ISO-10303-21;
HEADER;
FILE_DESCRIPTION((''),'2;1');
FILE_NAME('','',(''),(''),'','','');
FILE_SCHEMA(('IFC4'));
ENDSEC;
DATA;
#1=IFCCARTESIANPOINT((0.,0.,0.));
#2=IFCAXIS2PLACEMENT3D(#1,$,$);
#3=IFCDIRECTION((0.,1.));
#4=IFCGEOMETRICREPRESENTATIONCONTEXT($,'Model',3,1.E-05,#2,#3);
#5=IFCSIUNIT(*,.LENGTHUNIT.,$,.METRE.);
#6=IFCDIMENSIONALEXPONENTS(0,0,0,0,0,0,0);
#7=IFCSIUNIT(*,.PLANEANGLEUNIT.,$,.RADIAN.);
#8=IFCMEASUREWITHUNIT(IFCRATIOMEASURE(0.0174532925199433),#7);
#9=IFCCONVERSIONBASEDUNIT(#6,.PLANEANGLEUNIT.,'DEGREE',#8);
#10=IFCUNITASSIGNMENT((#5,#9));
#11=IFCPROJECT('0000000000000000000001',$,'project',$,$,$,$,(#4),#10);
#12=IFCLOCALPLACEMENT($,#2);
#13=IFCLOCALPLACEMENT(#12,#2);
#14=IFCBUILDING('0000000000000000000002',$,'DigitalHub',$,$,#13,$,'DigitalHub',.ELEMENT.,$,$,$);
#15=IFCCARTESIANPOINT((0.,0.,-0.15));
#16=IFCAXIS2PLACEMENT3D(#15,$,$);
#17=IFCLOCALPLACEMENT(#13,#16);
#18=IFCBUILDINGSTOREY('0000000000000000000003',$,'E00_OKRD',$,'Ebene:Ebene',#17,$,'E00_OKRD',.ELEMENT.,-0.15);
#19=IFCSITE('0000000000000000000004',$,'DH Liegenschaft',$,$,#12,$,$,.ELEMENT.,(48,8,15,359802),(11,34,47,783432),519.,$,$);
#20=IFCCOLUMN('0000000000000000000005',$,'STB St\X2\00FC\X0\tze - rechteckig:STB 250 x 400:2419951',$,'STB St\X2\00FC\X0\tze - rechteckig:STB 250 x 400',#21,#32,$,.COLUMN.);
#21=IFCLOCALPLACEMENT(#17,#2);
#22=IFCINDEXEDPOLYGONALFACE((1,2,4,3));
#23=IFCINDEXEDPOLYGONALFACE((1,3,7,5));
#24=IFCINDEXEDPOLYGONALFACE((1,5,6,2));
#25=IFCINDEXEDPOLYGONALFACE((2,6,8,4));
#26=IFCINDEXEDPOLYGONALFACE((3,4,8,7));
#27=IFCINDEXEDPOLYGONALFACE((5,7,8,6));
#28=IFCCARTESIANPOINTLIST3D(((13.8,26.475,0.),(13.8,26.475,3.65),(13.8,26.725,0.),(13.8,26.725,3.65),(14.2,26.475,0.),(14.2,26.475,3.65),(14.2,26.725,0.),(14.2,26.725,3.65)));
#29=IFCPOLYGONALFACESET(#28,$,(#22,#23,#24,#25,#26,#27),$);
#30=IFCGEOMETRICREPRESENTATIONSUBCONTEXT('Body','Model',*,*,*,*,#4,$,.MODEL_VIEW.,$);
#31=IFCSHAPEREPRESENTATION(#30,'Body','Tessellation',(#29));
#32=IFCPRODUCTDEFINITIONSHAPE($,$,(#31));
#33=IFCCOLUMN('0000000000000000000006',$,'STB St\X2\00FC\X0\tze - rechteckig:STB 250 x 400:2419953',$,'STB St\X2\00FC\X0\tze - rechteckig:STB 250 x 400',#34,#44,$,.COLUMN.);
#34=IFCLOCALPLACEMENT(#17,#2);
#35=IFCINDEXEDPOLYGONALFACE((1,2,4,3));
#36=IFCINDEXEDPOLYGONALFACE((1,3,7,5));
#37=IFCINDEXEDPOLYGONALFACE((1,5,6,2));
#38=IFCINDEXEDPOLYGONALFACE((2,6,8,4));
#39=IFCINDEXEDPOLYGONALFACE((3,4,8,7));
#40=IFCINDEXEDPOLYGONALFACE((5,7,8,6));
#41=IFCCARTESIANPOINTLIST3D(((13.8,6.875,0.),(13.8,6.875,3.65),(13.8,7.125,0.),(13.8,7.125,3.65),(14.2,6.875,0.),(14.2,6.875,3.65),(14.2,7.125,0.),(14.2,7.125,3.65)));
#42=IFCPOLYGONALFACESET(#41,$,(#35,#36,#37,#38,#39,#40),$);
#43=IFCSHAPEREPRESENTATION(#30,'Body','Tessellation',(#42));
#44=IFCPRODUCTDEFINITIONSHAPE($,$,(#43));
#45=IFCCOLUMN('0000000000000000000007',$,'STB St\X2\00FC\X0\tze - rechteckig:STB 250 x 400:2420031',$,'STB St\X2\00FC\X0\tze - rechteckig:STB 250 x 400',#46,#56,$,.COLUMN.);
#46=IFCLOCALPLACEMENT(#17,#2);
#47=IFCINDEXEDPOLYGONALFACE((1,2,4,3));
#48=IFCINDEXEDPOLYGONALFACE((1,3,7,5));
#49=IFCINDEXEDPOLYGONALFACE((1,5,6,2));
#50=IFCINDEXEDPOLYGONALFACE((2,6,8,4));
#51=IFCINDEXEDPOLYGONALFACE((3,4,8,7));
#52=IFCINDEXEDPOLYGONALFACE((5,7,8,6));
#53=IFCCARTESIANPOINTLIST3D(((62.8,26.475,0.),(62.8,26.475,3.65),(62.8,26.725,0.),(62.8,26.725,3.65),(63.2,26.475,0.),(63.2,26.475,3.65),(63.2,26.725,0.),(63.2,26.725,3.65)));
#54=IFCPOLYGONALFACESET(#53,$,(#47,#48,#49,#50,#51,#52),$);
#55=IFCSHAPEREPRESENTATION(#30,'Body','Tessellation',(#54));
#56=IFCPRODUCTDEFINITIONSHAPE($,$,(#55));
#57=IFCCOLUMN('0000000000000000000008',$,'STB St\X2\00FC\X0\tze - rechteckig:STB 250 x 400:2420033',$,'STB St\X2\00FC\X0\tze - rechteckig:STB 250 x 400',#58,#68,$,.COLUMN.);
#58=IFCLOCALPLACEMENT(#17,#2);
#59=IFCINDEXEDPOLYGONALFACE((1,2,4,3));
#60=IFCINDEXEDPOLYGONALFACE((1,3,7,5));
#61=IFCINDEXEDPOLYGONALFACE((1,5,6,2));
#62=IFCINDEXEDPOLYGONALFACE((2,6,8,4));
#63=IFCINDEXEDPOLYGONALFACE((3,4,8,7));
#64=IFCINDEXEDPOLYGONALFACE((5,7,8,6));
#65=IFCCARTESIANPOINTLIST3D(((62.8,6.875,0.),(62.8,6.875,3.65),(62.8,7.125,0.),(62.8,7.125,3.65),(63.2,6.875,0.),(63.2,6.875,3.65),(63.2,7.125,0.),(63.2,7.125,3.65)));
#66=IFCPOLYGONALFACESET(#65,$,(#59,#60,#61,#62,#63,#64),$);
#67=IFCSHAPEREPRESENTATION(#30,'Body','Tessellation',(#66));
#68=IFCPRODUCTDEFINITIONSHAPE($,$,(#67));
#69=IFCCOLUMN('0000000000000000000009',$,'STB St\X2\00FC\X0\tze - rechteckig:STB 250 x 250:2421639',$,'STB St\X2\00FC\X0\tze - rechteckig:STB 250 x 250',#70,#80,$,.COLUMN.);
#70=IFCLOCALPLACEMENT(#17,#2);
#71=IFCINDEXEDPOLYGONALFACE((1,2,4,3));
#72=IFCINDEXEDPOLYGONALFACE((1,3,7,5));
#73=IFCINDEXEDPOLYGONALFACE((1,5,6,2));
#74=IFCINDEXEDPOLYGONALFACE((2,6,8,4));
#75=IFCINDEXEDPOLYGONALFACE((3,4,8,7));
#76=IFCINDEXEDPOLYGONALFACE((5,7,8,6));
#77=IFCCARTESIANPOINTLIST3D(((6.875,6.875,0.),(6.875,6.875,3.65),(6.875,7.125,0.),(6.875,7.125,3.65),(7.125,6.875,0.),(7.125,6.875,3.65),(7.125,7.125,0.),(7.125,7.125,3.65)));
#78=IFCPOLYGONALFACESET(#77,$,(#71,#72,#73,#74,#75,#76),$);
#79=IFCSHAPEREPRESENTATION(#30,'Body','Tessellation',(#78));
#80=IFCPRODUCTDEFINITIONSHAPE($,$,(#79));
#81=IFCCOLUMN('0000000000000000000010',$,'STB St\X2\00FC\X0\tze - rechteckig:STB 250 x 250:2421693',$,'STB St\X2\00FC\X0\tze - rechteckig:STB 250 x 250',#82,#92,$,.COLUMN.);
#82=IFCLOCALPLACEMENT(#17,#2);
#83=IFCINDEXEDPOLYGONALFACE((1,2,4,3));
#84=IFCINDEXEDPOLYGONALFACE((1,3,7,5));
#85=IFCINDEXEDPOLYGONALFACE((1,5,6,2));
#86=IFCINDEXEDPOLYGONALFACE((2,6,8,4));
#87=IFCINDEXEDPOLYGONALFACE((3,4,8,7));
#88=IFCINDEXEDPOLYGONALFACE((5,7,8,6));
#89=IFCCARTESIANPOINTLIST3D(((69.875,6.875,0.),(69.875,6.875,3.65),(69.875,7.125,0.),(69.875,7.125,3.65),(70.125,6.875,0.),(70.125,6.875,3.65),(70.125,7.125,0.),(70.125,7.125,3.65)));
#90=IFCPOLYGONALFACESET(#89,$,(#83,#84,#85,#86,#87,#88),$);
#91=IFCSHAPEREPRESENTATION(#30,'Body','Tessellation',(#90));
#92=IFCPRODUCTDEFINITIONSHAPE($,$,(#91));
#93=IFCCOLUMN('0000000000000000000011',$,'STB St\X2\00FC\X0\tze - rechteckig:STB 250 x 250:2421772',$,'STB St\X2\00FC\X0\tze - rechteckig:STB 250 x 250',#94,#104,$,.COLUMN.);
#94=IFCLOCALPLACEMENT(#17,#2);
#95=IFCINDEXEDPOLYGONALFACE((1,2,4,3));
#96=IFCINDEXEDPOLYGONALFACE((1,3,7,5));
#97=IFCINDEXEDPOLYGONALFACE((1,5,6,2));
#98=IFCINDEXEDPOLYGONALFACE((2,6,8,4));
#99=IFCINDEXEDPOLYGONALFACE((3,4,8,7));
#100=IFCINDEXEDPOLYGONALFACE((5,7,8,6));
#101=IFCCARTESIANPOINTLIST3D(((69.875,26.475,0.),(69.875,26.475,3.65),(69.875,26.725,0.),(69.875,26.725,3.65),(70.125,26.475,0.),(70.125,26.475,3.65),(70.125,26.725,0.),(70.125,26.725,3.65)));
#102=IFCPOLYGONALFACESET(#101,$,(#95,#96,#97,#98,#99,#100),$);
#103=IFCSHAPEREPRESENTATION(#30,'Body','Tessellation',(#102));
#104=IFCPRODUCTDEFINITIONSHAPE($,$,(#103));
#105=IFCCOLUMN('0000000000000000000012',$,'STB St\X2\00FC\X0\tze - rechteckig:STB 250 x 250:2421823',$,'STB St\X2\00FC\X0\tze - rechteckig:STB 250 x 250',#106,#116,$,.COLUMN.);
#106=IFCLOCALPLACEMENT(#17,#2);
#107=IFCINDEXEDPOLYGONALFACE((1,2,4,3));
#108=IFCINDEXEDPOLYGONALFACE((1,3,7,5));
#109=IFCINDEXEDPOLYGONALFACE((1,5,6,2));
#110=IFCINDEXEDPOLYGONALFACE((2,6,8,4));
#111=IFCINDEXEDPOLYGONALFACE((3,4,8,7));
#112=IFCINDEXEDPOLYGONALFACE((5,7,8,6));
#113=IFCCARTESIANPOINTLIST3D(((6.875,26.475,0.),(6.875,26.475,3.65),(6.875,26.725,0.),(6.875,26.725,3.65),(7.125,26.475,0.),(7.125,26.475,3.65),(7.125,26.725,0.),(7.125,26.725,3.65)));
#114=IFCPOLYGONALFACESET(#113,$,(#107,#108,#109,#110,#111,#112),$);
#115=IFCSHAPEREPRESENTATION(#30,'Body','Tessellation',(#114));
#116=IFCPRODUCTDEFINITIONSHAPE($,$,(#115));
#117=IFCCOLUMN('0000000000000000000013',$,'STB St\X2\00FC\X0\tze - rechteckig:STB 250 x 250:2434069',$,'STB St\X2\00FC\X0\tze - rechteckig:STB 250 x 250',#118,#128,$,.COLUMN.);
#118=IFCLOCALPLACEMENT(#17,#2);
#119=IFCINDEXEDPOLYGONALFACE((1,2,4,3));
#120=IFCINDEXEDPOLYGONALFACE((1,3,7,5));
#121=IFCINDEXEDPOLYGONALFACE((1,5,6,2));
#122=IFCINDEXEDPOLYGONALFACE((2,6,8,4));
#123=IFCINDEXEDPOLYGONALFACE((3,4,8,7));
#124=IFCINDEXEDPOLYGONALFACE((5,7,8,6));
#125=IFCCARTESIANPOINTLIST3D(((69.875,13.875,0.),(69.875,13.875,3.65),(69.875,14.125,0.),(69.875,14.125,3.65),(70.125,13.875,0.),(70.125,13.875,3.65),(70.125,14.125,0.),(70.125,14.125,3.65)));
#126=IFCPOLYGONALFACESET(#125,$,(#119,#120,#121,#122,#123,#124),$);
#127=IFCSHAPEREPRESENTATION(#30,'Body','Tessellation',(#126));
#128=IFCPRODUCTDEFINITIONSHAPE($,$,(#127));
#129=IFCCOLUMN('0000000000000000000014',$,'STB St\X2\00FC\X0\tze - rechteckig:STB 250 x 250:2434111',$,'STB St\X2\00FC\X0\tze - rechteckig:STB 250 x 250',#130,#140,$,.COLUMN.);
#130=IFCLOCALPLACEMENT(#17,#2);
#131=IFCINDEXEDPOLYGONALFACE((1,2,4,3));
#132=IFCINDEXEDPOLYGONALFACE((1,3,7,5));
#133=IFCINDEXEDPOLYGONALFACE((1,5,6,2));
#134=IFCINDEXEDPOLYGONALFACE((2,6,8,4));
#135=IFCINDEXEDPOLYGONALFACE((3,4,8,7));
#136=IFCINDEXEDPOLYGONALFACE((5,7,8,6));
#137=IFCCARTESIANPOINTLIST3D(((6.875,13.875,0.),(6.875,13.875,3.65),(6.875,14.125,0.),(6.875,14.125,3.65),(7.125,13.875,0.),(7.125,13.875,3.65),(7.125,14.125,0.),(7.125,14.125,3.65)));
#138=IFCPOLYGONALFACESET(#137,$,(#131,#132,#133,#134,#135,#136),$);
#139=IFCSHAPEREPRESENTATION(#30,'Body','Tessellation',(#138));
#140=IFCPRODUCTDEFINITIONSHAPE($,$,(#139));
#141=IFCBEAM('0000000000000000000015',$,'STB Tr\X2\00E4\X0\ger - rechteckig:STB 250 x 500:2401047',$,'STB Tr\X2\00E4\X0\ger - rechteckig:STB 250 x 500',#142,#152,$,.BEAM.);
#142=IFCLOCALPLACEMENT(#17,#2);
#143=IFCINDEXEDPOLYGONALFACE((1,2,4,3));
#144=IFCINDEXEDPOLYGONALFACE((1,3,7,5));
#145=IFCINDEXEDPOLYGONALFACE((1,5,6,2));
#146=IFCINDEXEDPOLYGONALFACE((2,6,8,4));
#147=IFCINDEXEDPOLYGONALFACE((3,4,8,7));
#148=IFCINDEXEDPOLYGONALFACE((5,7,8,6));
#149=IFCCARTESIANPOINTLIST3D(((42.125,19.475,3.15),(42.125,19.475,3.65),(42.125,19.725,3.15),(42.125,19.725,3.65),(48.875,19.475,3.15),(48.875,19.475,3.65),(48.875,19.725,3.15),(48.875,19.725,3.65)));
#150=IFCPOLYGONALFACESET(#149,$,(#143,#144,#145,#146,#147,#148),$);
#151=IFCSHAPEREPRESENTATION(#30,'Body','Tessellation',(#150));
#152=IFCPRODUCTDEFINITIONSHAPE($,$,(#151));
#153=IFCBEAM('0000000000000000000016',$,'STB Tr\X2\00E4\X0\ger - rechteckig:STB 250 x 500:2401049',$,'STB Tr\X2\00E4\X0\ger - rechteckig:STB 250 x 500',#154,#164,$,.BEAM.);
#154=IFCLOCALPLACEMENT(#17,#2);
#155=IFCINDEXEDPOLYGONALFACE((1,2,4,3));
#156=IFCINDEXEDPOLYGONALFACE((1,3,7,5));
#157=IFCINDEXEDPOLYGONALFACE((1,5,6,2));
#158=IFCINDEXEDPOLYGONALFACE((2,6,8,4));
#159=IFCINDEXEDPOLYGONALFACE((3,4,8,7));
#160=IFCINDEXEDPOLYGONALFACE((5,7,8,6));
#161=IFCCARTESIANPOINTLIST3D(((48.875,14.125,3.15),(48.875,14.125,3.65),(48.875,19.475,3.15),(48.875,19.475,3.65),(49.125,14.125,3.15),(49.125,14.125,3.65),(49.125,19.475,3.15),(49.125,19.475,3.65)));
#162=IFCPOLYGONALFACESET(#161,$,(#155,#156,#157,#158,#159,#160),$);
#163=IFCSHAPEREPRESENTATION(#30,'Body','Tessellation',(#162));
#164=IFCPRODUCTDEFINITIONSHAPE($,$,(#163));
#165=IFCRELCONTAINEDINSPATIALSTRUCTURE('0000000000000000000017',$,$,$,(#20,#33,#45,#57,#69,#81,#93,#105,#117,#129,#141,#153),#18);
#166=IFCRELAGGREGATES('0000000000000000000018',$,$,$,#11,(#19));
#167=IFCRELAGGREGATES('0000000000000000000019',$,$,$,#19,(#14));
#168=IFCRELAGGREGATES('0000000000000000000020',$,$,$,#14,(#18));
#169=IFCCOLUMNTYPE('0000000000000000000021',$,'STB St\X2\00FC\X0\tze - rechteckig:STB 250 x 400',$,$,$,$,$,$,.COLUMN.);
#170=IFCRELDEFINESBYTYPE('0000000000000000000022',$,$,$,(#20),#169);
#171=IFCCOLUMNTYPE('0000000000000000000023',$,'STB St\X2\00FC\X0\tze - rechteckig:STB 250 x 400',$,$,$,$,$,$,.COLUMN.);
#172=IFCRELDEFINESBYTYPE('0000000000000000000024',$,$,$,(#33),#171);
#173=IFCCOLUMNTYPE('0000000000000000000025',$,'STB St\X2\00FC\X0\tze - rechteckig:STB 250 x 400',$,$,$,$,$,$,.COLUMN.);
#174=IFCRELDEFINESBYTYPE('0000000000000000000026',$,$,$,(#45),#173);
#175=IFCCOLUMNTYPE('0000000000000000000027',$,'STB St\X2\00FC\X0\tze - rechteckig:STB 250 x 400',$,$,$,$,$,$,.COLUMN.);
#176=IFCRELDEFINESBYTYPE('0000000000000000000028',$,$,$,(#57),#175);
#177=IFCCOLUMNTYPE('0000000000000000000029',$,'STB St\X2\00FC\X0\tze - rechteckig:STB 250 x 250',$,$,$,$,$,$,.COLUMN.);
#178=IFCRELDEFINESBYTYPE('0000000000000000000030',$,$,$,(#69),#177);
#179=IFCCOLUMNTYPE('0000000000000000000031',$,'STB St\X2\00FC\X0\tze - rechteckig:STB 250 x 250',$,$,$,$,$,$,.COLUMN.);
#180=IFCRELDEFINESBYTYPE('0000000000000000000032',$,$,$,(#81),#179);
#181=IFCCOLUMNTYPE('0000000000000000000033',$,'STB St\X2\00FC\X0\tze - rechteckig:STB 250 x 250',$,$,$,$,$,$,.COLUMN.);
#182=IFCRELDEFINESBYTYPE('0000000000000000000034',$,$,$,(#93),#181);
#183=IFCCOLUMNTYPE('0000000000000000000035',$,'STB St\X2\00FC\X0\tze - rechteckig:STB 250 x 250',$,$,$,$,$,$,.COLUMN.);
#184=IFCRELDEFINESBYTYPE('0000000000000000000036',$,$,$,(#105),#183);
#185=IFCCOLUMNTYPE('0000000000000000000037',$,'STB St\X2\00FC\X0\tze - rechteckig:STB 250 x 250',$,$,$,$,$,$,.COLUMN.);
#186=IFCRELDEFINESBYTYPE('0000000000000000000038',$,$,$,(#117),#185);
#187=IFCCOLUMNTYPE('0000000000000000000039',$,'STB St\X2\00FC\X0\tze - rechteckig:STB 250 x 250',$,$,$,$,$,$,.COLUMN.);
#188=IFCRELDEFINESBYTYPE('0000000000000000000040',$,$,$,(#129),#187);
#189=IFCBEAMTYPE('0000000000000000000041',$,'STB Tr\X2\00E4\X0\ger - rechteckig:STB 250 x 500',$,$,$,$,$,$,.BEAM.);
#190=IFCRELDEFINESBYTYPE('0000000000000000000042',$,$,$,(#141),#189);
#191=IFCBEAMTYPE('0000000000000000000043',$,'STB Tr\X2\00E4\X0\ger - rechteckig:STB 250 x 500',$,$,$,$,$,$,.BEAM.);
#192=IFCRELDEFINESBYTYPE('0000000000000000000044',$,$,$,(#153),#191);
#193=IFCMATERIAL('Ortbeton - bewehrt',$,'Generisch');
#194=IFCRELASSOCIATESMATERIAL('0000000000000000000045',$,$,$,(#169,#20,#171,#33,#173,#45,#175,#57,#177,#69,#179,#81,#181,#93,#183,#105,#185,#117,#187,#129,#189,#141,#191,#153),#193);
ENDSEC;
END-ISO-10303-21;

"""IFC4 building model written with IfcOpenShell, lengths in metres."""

from ifc_helpers import new_model, entity, si_unit, converted_unit, direction, frame, origin, place, context, subcontext, project, spatial, indexed_curve, outline, extrude, source, transform, mapped, material, type_object, type_shapes, element, save


model = new_model("IFC4")

# Units and contexts
model_context = context("Model", 3, precision=1e-05, world=origin(), true_north=direction((0.0, 1.0)))
body_context = subcontext(model_context, "Body", "Model", "MODEL_VIEW")
ifc_project = project(units=[si_unit("LENGTHUNIT", "METRE"), converted_unit("PLANEANGLEUNIT", "DEGREE", entity("IfcRatioMeasure", 0.0174532925199433), si_unit("PLANEANGLEUNIT", "RADIAN"), dimensions=[0, 0, 0, 0, 0, 0, 0])], contexts=[model_context])

# Site, building, storey
site_placement = place(None, frame((0.0, 0.0, 0.0)))
site = spatial("IfcSite", under=ifc_project, at=site_placement, Name="DH Liegenschaft", CompositionType="ELEMENT", RefLatitude=(48, 8, 15, 359802), RefLongitude=(11, 34, 47, 783432), RefElevation=519.0)
building_placement = place(site_placement, origin())
building = spatial("IfcBuilding", under=site, at=building_placement, Name="DigitalHub", LongName="DigitalHub", CompositionType="ELEMENT")
storey_placement = place(building_placement, frame((0.0, 0.0, -0.15)))
storey = spatial("IfcBuildingStorey", under=building, at=storey_placement, Name="E00_OKRD", ObjectType="Ebene:Ebene", LongName="E00_OKRD", CompositionType="ELEMENT", Elevation=-0.15)

# Columns
ifc_material_1 = material(Name="Ortbeton - bewehrt", Category="Generisch")
column_type_1 = type_object("IfcColumnType", Name="STB Stütze - rechteckig:STB 250 x 400", PredefinedType="COLUMN", material=ifc_material_1)
shared_shape_1 = source(origin(), body_context, "Body", "SweptSolid", [
    extrude(outline(indexed_curve([(-0.125, -0.2), (0.125, -0.2), (0.125, 0.2), (-0.125, 0.2), (-0.125, -0.2)], self_intersect=False)), frame((14.0, 26.6, -0.15), z_axis=(0.0, 0.0, 1.0), x_axis=(0.0, -1.0, 0.0)), (0.0, 0.0, 1.0), 3.65),
])
type_shapes(column_type_1, [shared_shape_1])
column_1_placement = place(storey_placement, frame((0.0, 0.0, 0.15)))
element("IfcColumn", 1, at=column_1_placement, inside=storey, type_object=column_type_1, material=ifc_material_1, Name="STB Stütze - rechteckig:STB 250 x 400:2419951", ObjectType="STB Stütze - rechteckig:STB 250 x 400", PredefinedType="COLUMN", context=body_context, shape_type="MappedRepresentation", body=[
    mapped(shared_shape_1, transform((0.0, 0.0, 0.0), scale=1.0)),
])
column_type_2 = type_object("IfcColumnType", Name="STB Stütze - rechteckig:STB 250 x 400", PredefinedType="COLUMN", material=ifc_material_1)
shared_shape_2 = source(origin(), body_context, "Body", "SweptSolid", [
    extrude(outline(indexed_curve([(-0.125, -0.2), (0.125, -0.2), (0.125, 0.2), (-0.125, 0.2), (-0.125, -0.2)], self_intersect=False)), frame((14.0, 7.0, -0.15), z_axis=(0.0, 0.0, 1.0), x_axis=(0.0, -1.0, 0.0)), (0.0, 0.0, 1.0), 3.65),
])
type_shapes(column_type_2, [shared_shape_2])
column_2_placement = place(storey_placement, frame((0.0, 0.0, 0.15)))
element("IfcColumn", 2, at=column_2_placement, inside=storey, type_object=column_type_2, material=ifc_material_1, Name="STB Stütze - rechteckig:STB 250 x 400:2419953", ObjectType="STB Stütze - rechteckig:STB 250 x 400", PredefinedType="COLUMN", context=body_context, shape_type="MappedRepresentation", body=[
    mapped(shared_shape_2, transform((0.0, 0.0, 0.0), scale=1.0)),
])
column_type_3 = type_object("IfcColumnType", Name="STB Stütze - rechteckig:STB 250 x 400", PredefinedType="COLUMN", material=ifc_material_1)
shared_shape_3 = source(origin(), body_context, "Body", "SweptSolid", [
    extrude(outline(indexed_curve([(-0.125, -0.2), (0.125, -0.2), (0.125, 0.2), (-0.125, 0.2), (-0.125, -0.2)], self_intersect=False)), frame((63.0, 26.6, -0.15), z_axis=(0.0, 0.0, 1.0), x_axis=(0.0, -1.0, 0.0)), (0.0, 0.0, 1.0), 3.65),
])
type_shapes(column_type_3, [shared_shape_3])
column_3_placement = place(storey_placement, frame((0.0, 0.0, 0.15)))
element("IfcColumn", 3, at=column_3_placement, inside=storey, type_object=column_type_3, material=ifc_material_1, Name="STB Stütze - rechteckig:STB 250 x 400:2420031", ObjectType="STB Stütze - rechteckig:STB 250 x 400", PredefinedType="COLUMN", context=body_context, shape_type="MappedRepresentation", body=[
    mapped(shared_shape_3, transform((0.0, 0.0, 0.0), scale=1.0)),
])
column_type_4 = type_object("IfcColumnType", Name="STB Stütze - rechteckig:STB 250 x 400", PredefinedType="COLUMN", material=ifc_material_1)
shared_shape_4 = source(origin(), body_context, "Body", "SweptSolid", [
    extrude(outline(indexed_curve([(-0.125, -0.2), (0.125, -0.2), (0.125, 0.2), (-0.125, 0.2), (-0.125, -0.2)], self_intersect=False)), frame((63.0, 7.0, -0.15), z_axis=(0.0, 0.0, 1.0), x_axis=(0.0, -1.0, 0.0)), (0.0, 0.0, 1.0), 3.65),
])
type_shapes(column_type_4, [shared_shape_4])
column_4_placement = place(storey_placement, frame((0.0, 0.0, 0.15)))
element("IfcColumn", 4, at=column_4_placement, inside=storey, type_object=column_type_4, material=ifc_material_1, Name="STB Stütze - rechteckig:STB 250 x 400:2420033", ObjectType="STB Stütze - rechteckig:STB 250 x 400", PredefinedType="COLUMN", context=body_context, shape_type="MappedRepresentation", body=[
    mapped(shared_shape_4, transform((0.0, 0.0, 0.0), scale=1.0)),
])
column_type_5 = type_object("IfcColumnType", Name="STB Stütze - rechteckig:STB 250 x 250", PredefinedType="COLUMN", material=ifc_material_1)
shared_shape_5 = source(origin(), body_context, "Body", "SweptSolid", [
    extrude(outline(indexed_curve([(-0.125, -0.125), (0.125, -0.125), (0.125, 0.125), (-0.125, 0.125), (-0.125, -0.125)], self_intersect=False)), frame((7.0, 7.0, -0.15), z_axis=(0.0, 0.0, 1.0), x_axis=(0.0, -1.0, 0.0)), (0.0, 0.0, 1.0), 3.65),
])
type_shapes(column_type_5, [shared_shape_5])
column_5_placement = place(storey_placement, frame((0.0, 0.0, 0.15)))
element("IfcColumn", 5, at=column_5_placement, inside=storey, type_object=column_type_5, material=ifc_material_1, Name="STB Stütze - rechteckig:STB 250 x 250:2421639", ObjectType="STB Stütze - rechteckig:STB 250 x 250", PredefinedType="COLUMN", context=body_context, shape_type="MappedRepresentation", body=[
    mapped(shared_shape_5, transform((0.0, 0.0, 0.0), scale=1.0)),
])
column_type_6 = type_object("IfcColumnType", Name="STB Stütze - rechteckig:STB 250 x 250", PredefinedType="COLUMN", material=ifc_material_1)
shared_shape_6 = source(origin(), body_context, "Body", "SweptSolid", [
    extrude(outline(indexed_curve([(-0.125, -0.125), (0.125, -0.125), (0.125, 0.125), (-0.125, 0.125), (-0.125, -0.125)], self_intersect=False)), frame((70.0, 7.0, -0.15), z_axis=(0.0, 0.0, 1.0), x_axis=(0.0, -1.0, 0.0)), (0.0, 0.0, 1.0), 3.65),
])
type_shapes(column_type_6, [shared_shape_6])
column_6_placement = place(storey_placement, frame((0.0, 0.0, 0.15)))
element("IfcColumn", 6, at=column_6_placement, inside=storey, type_object=column_type_6, material=ifc_material_1, Name="STB Stütze - rechteckig:STB 250 x 250:2421693", ObjectType="STB Stütze - rechteckig:STB 250 x 250", PredefinedType="COLUMN", context=body_context, shape_type="MappedRepresentation", body=[
    mapped(shared_shape_6, transform((0.0, 0.0, 0.0), scale=1.0)),
])
column_type_7 = type_object("IfcColumnType", Name="STB Stütze - rechteckig:STB 250 x 250", PredefinedType="COLUMN", material=ifc_material_1)
shared_shape_7 = source(origin(), body_context, "Body", "SweptSolid", [
    extrude(outline(indexed_curve([(-0.125, -0.125), (0.125, -0.125), (0.125, 0.125), (-0.125, 0.125), (-0.125, -0.125)], self_intersect=False)), frame((70.0, 26.6, -0.15), z_axis=(0.0, 0.0, 1.0), x_axis=(0.0, -1.0, 0.0)), (0.0, 0.0, 1.0), 3.65),
])
type_shapes(column_type_7, [shared_shape_7])
column_7_placement = place(storey_placement, frame((0.0, 0.0, 0.15)))
element("IfcColumn", 7, at=column_7_placement, inside=storey, type_object=column_type_7, material=ifc_material_1, Name="STB Stütze - rechteckig:STB 250 x 250:2421772", ObjectType="STB Stütze - rechteckig:STB 250 x 250", PredefinedType="COLUMN", context=body_context, shape_type="MappedRepresentation", body=[
    mapped(shared_shape_7, transform((0.0, 0.0, 0.0), scale=1.0)),
])
column_type_8 = type_object("IfcColumnType", Name="STB Stütze - rechteckig:STB 250 x 250", PredefinedType="COLUMN", material=ifc_material_1)
shared_shape_8 = source(origin(), body_context, "Body", "SweptSolid", [
    extrude(outline(indexed_curve([(-0.125, -0.125), (0.125, -0.125), (0.125, 0.125), (-0.125, 0.125), (-0.125, -0.125)], self_intersect=False)), frame((7.0, 26.6, -0.15), z_axis=(0.0, 0.0, 1.0), x_axis=(0.0, -1.0, 0.0)), (0.0, 0.0, 1.0), 3.65),
])
type_shapes(column_type_8, [shared_shape_8])
column_8_placement = place(storey_placement, frame((0.0, 0.0, 0.15)))
element("IfcColumn", 8, at=column_8_placement, inside=storey, type_object=column_type_8, material=ifc_material_1, Name="STB Stütze - rechteckig:STB 250 x 250:2421823", ObjectType="STB Stütze - rechteckig:STB 250 x 250", PredefinedType="COLUMN", context=body_context, shape_type="MappedRepresentation", body=[
    mapped(shared_shape_8, transform((0.0, 0.0, 0.0), scale=1.0)),
])
column_type_9 = type_object("IfcColumnType", Name="STB Stütze - rechteckig:STB 250 x 250", PredefinedType="COLUMN", material=ifc_material_1)
shared_shape_9 = source(origin(), body_context, "Body", "SweptSolid", [
    extrude(outline(indexed_curve([(-0.125, -0.125), (0.125, -0.125), (0.125, 0.125), (-0.125, 0.125), (-0.125, -0.125)], self_intersect=False)), frame((70.0, 14.0, -0.15), z_axis=(0.0, 0.0, 1.0), x_axis=(0.0, -1.0, 0.0)), (0.0, 0.0, 1.0), 3.65),
])
type_shapes(column_type_9, [shared_shape_9])
column_9_placement = place(storey_placement, frame((0.0, 0.0, 0.15)))
element("IfcColumn", 9, at=column_9_placement, inside=storey, type_object=column_type_9, material=ifc_material_1, Name="STB Stütze - rechteckig:STB 250 x 250:2434069", ObjectType="STB Stütze - rechteckig:STB 250 x 250", PredefinedType="COLUMN", context=body_context, shape_type="MappedRepresentation", body=[
    mapped(shared_shape_9, transform((0.0, 0.0, 0.0), scale=1.0)),
])
column_type_10 = type_object("IfcColumnType", Name="STB Stütze - rechteckig:STB 250 x 250", PredefinedType="COLUMN", material=ifc_material_1)
shared_shape_10 = source(origin(), body_context, "Body", "SweptSolid", [
    extrude(outline(indexed_curve([(-0.125, -0.125), (0.125, -0.125), (0.125, 0.125), (-0.125, 0.125), (-0.125, -0.125)], self_intersect=False)), frame((7.0, 14.0, -0.15), z_axis=(0.0, 0.0, 1.0), x_axis=(0.0, -1.0, 0.0)), (0.0, 0.0, 1.0), 3.65),
])
type_shapes(column_type_10, [shared_shape_10])
column_10_placement = place(storey_placement, frame((0.0, 0.0, 0.15)))
element("IfcColumn", 10, at=column_10_placement, inside=storey, type_object=column_type_10, material=ifc_material_1, Name="STB Stütze - rechteckig:STB 250 x 250:2434111", ObjectType="STB Stütze - rechteckig:STB 250 x 250", PredefinedType="COLUMN", context=body_context, shape_type="MappedRepresentation", body=[
    mapped(shared_shape_10, transform((0.0, 0.0, 0.0), scale=1.0)),
])

# Beams
beam_type_1 = type_object("IfcBeamType", Name="STB Träger - rechteckig:STB 250 x 500", PredefinedType="BEAM", material=ifc_material_1)
shared_shape_11 = source(origin(), body_context, "Body", "SweptSolid", [
    extrude(outline(indexed_curve([(-0.25, -0.125), (0.25, -0.125), (0.25, 0.125), (-0.25, 0.125), (-0.25, -0.125)], self_intersect=False)), frame((42.125, 19.6, 3.25), z_axis=(1.0, 0.0, 0.0), x_axis=(0.0, 0.0, -1.0)), (0.0, 0.0, 1.0), 6.75),
])
type_shapes(beam_type_1, [shared_shape_11])
beam_1_placement = place(storey_placement, frame((0.0, 0.0, 0.15)))
element("IfcBeam", 11, at=beam_1_placement, inside=storey, type_object=beam_type_1, material=ifc_material_1, Name="STB Träger - rechteckig:STB 250 x 500:2401047", ObjectType="STB Träger - rechteckig:STB 250 x 500", PredefinedType="BEAM", context=body_context, shape_type="MappedRepresentation", body=[
    mapped(shared_shape_11, transform((0.0, 0.0, 0.0), scale=1.0)),
])
beam_type_2 = type_object("IfcBeamType", Name="STB Träger - rechteckig:STB 250 x 500", PredefinedType="BEAM", material=ifc_material_1)
shared_shape_12 = source(origin(), body_context, "Body", "SweptSolid", [
    extrude(outline(indexed_curve([(-0.125, -0.25), (0.125, -0.25), (0.125, 0.25), (-0.125, 0.25), (-0.125, -0.25)], self_intersect=False)), frame((49.0, 19.475, 3.25), z_axis=(0.0, -1.0, 0.0), x_axis=(-1.0, 0.0, 0.0)), (0.0, 0.0, 1.0), 5.35),
])
type_shapes(beam_type_2, [shared_shape_12])
beam_2_placement = place(storey_placement, frame((0.0, 0.0, 0.15)))
element("IfcBeam", 12, at=beam_2_placement, inside=storey, type_object=beam_type_2, material=ifc_material_1, Name="STB Träger - rechteckig:STB 250 x 500:2401049", ObjectType="STB Träger - rechteckig:STB 250 x 500", PredefinedType="BEAM", context=body_context, shape_type="MappedRepresentation", body=[
    mapped(shared_shape_12, transform((0.0, 0.0, 0.0), scale=1.0)),
])

save(model, "model.ifc")
